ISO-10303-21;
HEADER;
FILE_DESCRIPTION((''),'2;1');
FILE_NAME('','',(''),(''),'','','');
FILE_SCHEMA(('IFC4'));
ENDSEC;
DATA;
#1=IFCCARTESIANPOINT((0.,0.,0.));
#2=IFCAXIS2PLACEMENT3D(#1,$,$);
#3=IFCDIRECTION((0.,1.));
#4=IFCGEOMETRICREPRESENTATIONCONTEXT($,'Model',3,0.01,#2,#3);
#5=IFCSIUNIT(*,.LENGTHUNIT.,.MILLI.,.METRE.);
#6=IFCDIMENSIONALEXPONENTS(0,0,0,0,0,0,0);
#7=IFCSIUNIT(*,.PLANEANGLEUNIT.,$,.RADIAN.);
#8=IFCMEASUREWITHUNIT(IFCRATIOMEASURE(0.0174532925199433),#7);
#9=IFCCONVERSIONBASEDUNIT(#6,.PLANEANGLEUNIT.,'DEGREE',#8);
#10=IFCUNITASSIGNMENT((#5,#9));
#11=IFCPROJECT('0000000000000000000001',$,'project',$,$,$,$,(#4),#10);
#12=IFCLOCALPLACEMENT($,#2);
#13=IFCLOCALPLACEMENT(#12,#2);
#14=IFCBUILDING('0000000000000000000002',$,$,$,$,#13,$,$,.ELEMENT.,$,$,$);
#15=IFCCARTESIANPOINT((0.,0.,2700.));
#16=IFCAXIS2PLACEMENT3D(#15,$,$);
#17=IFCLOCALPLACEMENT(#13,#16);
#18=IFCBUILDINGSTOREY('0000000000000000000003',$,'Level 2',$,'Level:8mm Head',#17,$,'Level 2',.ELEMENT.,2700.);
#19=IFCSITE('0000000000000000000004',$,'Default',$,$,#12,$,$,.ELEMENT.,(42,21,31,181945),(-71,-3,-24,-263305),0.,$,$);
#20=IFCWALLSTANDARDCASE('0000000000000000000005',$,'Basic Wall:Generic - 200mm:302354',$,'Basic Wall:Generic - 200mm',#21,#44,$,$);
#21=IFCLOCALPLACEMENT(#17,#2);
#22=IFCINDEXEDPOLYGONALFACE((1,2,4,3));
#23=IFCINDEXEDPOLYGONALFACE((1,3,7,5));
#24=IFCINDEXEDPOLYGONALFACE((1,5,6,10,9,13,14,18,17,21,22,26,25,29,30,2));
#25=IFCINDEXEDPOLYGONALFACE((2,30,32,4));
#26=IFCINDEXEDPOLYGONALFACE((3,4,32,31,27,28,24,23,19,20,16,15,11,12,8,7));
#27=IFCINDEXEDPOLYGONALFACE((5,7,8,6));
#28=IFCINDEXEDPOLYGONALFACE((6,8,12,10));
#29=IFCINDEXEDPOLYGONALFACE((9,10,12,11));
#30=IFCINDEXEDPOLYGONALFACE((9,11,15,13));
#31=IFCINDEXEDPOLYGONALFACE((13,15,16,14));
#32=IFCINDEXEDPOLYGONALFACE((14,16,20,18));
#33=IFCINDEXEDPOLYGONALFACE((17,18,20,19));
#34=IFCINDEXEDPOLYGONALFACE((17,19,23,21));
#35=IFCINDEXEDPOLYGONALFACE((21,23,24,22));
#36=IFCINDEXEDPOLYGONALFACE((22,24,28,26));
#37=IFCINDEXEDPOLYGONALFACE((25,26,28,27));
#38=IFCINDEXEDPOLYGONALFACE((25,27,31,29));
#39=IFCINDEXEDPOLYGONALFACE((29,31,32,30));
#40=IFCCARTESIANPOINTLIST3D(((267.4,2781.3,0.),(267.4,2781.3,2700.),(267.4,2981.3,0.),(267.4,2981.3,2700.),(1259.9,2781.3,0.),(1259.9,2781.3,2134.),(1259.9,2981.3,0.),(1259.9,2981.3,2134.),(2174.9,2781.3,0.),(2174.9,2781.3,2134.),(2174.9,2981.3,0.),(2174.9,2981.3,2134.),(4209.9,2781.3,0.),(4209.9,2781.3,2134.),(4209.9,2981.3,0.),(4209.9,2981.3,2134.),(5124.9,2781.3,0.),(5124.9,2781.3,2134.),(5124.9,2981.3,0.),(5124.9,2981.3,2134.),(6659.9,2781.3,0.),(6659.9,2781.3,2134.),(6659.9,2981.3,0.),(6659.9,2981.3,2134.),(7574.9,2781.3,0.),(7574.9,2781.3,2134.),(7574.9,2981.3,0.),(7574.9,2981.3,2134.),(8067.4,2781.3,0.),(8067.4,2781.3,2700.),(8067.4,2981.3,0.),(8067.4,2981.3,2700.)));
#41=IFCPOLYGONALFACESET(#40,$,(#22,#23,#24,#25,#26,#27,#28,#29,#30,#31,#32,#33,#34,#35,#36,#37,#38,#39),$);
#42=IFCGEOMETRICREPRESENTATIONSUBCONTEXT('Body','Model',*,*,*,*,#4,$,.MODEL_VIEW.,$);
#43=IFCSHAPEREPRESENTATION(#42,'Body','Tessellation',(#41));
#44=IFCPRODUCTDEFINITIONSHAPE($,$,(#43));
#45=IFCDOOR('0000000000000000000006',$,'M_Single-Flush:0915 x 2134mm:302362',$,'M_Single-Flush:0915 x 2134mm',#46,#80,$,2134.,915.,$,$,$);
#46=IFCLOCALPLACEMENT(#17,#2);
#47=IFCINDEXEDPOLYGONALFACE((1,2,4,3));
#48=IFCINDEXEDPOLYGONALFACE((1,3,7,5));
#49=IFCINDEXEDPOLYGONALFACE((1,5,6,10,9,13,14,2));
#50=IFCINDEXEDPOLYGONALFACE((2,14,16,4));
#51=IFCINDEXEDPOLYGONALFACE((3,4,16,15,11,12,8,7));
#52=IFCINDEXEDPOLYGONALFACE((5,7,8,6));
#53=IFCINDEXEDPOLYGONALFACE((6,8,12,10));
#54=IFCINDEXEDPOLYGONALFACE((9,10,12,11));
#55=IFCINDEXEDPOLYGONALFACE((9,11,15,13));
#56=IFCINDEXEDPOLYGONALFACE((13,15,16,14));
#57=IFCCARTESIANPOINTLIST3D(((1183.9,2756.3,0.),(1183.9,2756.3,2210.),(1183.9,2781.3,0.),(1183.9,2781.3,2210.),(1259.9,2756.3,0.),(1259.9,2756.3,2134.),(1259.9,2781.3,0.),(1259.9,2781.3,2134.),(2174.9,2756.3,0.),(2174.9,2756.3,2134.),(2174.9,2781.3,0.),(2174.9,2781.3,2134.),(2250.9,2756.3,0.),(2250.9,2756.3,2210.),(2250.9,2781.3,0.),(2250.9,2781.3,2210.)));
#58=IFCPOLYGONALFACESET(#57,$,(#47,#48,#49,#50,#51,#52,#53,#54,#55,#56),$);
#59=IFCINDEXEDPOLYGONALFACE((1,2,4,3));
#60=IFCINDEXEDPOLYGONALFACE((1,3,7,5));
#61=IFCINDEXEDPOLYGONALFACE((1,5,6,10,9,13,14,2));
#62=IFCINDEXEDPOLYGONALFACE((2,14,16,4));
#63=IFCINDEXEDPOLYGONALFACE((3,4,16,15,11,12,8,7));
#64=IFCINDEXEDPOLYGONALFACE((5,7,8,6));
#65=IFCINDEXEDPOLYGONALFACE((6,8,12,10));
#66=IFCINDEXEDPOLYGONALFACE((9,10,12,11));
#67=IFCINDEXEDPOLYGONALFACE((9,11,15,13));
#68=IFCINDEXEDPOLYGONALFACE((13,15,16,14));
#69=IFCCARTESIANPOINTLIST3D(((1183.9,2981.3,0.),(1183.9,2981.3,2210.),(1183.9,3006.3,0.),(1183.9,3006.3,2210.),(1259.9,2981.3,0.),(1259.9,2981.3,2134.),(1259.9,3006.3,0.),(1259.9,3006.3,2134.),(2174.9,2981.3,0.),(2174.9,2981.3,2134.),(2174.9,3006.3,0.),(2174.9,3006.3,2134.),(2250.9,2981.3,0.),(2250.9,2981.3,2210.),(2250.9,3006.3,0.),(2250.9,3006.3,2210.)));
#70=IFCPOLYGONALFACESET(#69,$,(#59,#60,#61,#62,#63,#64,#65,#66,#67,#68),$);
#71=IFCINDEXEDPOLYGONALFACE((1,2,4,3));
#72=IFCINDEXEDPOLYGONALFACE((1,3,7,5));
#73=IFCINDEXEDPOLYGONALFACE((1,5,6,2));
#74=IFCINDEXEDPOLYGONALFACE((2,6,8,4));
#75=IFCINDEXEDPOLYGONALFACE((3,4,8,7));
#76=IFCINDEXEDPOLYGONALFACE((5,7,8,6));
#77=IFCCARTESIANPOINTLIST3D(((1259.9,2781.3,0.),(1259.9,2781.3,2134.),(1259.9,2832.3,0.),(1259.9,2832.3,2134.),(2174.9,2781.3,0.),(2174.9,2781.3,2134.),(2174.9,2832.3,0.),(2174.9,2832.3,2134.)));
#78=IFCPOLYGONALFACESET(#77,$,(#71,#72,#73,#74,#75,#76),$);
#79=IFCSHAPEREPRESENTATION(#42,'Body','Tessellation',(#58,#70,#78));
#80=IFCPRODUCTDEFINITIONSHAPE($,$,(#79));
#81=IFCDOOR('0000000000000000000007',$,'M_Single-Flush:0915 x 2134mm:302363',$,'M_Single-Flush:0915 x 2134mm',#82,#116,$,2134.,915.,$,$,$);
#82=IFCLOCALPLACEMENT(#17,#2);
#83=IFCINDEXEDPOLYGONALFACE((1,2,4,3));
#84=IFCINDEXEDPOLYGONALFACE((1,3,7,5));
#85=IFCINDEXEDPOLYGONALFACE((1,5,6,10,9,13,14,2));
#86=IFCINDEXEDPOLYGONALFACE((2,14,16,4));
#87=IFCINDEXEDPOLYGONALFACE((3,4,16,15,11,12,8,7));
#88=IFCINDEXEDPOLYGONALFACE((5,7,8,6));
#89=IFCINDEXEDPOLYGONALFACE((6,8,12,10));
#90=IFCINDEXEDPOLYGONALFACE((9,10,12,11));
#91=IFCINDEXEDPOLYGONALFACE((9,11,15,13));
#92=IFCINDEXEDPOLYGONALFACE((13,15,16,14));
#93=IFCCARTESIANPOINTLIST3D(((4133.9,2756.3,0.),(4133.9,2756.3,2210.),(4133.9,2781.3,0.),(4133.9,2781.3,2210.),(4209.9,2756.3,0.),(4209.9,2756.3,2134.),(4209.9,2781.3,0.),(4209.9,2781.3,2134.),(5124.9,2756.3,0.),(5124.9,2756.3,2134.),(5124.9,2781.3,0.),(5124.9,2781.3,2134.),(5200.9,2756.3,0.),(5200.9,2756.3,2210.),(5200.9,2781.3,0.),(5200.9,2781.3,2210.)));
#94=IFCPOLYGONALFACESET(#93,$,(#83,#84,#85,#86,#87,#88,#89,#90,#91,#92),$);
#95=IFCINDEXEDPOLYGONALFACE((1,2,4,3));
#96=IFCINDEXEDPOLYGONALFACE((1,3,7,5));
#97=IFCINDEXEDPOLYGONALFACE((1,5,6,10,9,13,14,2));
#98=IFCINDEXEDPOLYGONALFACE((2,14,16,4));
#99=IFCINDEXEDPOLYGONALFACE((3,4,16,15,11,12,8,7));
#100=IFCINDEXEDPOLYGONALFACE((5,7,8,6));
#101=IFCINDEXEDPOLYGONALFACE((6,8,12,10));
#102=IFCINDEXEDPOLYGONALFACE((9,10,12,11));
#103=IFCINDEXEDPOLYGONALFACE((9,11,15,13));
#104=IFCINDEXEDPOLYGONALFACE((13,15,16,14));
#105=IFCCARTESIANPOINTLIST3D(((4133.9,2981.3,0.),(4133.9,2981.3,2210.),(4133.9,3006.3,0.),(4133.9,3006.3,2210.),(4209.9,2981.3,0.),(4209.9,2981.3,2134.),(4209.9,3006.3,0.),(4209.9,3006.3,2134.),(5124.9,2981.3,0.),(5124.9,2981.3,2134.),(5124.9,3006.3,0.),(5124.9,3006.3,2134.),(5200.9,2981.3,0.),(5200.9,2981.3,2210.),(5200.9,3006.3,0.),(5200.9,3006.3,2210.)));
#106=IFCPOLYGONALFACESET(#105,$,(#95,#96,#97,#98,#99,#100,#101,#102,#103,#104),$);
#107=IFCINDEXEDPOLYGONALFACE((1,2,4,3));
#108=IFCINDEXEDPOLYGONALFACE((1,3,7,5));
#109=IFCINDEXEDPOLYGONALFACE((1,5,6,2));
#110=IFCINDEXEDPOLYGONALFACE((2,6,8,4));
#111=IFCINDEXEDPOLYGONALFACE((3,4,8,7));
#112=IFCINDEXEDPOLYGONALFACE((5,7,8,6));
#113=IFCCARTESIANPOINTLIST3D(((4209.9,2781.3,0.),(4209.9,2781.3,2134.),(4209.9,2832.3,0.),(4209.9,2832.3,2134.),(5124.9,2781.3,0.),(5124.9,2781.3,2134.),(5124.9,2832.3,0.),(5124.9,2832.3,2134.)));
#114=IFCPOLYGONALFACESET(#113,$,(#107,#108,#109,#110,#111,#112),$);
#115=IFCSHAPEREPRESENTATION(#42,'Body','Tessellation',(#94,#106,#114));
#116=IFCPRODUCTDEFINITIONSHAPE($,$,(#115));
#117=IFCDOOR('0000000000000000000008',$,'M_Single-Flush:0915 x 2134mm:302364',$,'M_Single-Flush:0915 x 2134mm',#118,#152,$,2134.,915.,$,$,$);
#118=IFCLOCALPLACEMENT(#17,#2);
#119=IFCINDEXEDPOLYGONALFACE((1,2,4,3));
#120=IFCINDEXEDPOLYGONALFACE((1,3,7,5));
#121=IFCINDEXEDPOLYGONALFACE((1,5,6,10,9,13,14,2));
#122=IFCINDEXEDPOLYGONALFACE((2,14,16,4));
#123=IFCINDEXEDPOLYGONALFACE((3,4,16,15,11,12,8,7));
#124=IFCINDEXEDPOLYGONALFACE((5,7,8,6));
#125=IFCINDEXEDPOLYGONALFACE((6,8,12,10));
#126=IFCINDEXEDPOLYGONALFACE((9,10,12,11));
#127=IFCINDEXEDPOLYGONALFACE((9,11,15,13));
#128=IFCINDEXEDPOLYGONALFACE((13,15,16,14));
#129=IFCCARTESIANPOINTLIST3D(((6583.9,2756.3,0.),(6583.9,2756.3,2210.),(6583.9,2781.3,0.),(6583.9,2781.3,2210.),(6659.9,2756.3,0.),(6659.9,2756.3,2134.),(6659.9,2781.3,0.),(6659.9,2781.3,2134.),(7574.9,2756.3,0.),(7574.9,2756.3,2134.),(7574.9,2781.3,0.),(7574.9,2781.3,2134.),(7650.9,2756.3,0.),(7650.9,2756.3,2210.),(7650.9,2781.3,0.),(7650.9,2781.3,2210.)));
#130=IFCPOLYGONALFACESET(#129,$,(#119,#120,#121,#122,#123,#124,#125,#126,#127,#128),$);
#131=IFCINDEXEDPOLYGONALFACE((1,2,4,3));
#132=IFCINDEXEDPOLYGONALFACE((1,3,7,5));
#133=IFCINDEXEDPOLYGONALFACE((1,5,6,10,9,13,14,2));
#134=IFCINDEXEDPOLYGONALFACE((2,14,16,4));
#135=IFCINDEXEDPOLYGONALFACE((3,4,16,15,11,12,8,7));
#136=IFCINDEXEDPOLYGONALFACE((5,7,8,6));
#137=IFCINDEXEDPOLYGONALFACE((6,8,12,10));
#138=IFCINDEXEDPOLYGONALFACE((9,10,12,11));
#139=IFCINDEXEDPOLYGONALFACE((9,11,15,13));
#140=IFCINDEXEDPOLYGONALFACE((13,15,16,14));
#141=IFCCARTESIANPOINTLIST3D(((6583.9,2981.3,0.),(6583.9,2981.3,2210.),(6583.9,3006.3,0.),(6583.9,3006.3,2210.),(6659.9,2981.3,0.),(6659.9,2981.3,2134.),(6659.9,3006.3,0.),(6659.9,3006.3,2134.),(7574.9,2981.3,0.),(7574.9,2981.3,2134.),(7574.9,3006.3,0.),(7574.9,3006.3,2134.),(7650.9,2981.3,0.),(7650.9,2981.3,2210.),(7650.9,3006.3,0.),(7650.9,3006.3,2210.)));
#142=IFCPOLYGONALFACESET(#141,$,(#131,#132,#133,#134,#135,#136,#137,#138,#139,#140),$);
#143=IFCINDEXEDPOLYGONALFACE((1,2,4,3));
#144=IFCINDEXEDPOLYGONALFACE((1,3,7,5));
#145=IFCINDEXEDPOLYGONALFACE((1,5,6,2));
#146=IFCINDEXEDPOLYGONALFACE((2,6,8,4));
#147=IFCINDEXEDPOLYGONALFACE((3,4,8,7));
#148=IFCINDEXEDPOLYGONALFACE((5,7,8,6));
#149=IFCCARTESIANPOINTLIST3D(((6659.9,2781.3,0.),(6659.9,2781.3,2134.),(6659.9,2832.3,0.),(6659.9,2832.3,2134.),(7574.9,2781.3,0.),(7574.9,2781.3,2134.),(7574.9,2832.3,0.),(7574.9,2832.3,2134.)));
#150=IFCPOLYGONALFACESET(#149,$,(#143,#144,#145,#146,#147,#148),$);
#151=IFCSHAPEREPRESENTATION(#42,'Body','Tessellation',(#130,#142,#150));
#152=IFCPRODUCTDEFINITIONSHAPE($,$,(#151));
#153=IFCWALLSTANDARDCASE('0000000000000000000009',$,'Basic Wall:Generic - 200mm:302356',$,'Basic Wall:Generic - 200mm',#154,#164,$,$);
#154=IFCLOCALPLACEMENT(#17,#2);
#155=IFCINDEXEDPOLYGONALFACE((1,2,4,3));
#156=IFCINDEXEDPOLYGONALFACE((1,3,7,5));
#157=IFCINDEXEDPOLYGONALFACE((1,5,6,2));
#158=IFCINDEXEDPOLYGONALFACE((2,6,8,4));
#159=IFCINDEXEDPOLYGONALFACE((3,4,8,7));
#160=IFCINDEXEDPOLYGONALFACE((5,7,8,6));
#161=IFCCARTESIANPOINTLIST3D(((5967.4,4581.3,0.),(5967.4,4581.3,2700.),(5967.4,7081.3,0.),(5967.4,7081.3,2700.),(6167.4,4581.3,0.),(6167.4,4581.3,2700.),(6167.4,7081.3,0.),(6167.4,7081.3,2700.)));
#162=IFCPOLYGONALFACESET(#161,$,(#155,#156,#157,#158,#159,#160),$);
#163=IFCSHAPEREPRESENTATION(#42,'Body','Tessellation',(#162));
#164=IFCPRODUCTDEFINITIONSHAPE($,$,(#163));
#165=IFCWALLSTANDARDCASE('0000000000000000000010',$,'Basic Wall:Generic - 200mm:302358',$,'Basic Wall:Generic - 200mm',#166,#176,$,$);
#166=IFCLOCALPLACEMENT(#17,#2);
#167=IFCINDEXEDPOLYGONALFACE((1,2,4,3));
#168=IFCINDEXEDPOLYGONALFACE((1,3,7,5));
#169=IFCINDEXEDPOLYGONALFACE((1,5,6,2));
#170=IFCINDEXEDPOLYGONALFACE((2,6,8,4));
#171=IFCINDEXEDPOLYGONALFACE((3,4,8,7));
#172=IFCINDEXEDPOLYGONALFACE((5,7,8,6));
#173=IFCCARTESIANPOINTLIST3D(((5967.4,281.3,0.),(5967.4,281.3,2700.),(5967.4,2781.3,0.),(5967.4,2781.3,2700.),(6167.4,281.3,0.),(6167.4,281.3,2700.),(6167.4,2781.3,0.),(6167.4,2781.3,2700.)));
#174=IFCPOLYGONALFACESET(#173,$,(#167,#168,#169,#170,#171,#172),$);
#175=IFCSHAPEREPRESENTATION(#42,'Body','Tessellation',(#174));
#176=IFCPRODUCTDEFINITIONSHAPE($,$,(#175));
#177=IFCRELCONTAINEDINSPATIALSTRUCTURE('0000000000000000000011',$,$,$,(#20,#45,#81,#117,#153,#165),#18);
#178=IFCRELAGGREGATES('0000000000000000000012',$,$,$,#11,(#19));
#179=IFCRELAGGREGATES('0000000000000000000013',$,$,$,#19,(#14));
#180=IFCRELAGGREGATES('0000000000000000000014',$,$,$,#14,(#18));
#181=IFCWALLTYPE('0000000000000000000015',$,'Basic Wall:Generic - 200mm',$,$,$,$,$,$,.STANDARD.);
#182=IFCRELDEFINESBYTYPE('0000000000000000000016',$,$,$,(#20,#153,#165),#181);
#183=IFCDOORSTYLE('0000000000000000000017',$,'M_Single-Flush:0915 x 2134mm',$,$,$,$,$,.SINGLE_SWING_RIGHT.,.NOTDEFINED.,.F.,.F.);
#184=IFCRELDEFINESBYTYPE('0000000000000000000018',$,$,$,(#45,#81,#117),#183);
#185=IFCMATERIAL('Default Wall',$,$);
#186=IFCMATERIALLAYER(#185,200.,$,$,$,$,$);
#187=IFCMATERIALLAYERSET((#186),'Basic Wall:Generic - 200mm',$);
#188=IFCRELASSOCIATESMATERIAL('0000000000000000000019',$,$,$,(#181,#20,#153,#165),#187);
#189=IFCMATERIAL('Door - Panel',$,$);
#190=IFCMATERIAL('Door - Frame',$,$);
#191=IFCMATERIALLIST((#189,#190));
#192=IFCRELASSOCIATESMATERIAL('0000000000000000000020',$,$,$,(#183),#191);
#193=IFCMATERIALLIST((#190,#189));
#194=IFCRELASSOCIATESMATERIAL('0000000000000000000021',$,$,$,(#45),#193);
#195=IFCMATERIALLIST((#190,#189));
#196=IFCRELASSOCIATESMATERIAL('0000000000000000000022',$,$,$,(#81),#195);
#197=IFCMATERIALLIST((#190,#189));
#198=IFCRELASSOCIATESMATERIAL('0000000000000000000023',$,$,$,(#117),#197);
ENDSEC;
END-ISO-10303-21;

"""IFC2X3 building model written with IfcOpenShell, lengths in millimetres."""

from ifc_helpers import new_model, entity, si_unit, converted_unit, direction, frame, frame_2d, origin, place, context, subcontext, project, spatial, polyline, rectangle, outline, extrude, source, transform, mapped, material, material_list, layer, layer_set, layer_usage, type_object, type_shapes, element, fill, save


model = new_model("IFC2X3")

# Units and contexts
model_context = context("Model", 3, precision=0.01, world=origin(), true_north=direction((0.0, 1.0)))
body_context = subcontext(model_context, "Body", "Model", "MODEL_VIEW")
ifc_project = project(units=[si_unit("LENGTHUNIT", "METRE", prefix="MILLI"), converted_unit("PLANEANGLEUNIT", "DEGREE", entity("IfcRatioMeasure", 0.0174532925199433), si_unit("PLANEANGLEUNIT", "RADIAN"), dimensions=[0, 0, 0, 0, 0, 0, 0])], contexts=[model_context])

# Site, building, storey
site_placement = place(None, origin())
site = spatial("IfcSite", under=ifc_project, at=site_placement, Name="Default", CompositionType="ELEMENT", RefLatitude=(42, 21, 31, 181945), RefLongitude=(-71, -3, -24, -263305), RefElevation=0.0)
building_placement = place(site_placement, origin())
building = spatial("IfcBuilding", under=site, at=building_placement, CompositionType="ELEMENT")
storey_placement = place(building_placement, frame((0.0, 0.0, 2700.0)))
storey = spatial("IfcBuildingStorey", under=building, at=storey_placement, Name="Level 2", ObjectType="Level:8mm Head", LongName="Level 2", CompositionType="ELEMENT", Elevation=2700.0)

# Shared definitions
ifc_material_1 = material(Name="Default Wall")
ifc_layer = layer(ifc_material_1, 200.0)
ifc_layer_set = layer_set([ifc_layer], Name="Basic Wall:Generic - 200mm")
wall_type = type_object("IfcWallType", Name="Basic Wall:Generic - 200mm", PredefinedType="STANDARD", material=ifc_layer_set)

# Wall, openings, doors
ifc_layer_usage_1 = layer_usage(ifc_layer_set, "AXIS2", "NEGATIVE", 100.0)
wall_1_placement = place(storey_placement, frame((8067.4, 2881.3, 0.0), z_axis=(0.0, 0.0, 1.0), x_axis=(-1.0, 0.0, 0.0)))
wall_1 = element("IfcWallStandardCase", 1, at=wall_1_placement, inside=storey, type_object=wall_type, material=ifc_layer_usage_1, Name="Basic Wall:Generic - 200mm:302354", ObjectType="Basic Wall:Generic - 200mm", context=body_context, shape_type="SweptSolid", body=[
    extrude(rectangle(XDim=7800.0, YDim=200.0, at=frame_2d((3900.0, 0.0), x_axis=(-1.0, 0.0))), origin(), (0.0, 0.0, 1.0), 2700.0),
])
opening_1_placement = place(wall_1_placement, frame((5892.5, -100.0, 0.0)))
opening_1 = element("IfcOpeningElement", 2, at=opening_1_placement, cuts=wall_1, ObjectType="Opening", context=body_context, shape_type="SweptSolid", body=[
    extrude(rectangle(XDim=915.0, YDim=2134.0, at=frame_2d((1067.0, 457.5), x_axis=(0.0, 1.0))), frame((0.0, 0.0, 0.0), z_axis=(0.0, 1.0, 0.0), x_axis=(0.0, 0.0, 1.0)), (0.0, 0.0, 1.0), 200.0),
])
opening_2_placement = place(wall_1_placement, frame((2942.5, -100.0, 0.0)))
opening_2 = element("IfcOpeningElement", 3, at=opening_2_placement, cuts=wall_1, ObjectType="Opening", context=body_context, shape_type="SweptSolid", body=[
    extrude(rectangle(XDim=915.0, YDim=2134.0, at=frame_2d((1067.0, 457.5), x_axis=(0.0, 1.0))), frame((0.0, 0.0, 0.0), z_axis=(0.0, 1.0, 0.0), x_axis=(0.0, 0.0, 1.0)), (0.0, 0.0, 1.0), 200.0),
])
opening_3_placement = place(wall_1_placement, frame((492.5, -100.0, 0.0)))
opening_3 = element("IfcOpeningElement", 4, at=opening_3_placement, cuts=wall_1, ObjectType="Opening", context=body_context, shape_type="SweptSolid", body=[
    extrude(rectangle(XDim=915.0, YDim=2134.0, at=frame_2d((1067.0, 457.5), x_axis=(0.0, 1.0))), frame((0.0, 0.0, 0.0), z_axis=(0.0, 1.0, 0.0), x_axis=(0.0, 0.0, 1.0)), (0.0, 0.0, 1.0), 200.0),
])
ifc_material_2 = material(Name="Door - Frame")
ifc_material_3 = material(Name="Door - Panel")
ifc_material_list_1 = material_list([ifc_material_2, ifc_material_3])
ifc_material_list_2 = material_list([ifc_material_3, ifc_material_2])
door_style = type_object("IfcDoorStyle", Name="M_Single-Flush:0915 x 2134mm", ConstructionType="NOTDEFINED", OperationType="SINGLE_SWING_RIGHT", ParameterTakesPrecedence=False, Sizeable=False, material=ifc_material_list_2)
shared_shape_1 = source(origin(), body_context, "Body", "SweptSolid", [
    extrude(outline(polyline([(-533.5, -1124.0), (533.5, -1124.0), (533.5, 1086.0), (457.5, 1086.0), (457.5, -1048.0), (-457.5, -1048.0), (-457.5, 1086.0), (-533.5, 1086.0), (-533.5, -1124.0)])), frame((457.5, 200.0, 1086.0), z_axis=(0.0, 1.0, 0.0), x_axis=(1.0, 0.0, 0.0)), (0.0, 0.0, 1.0), 25.0),
    extrude(outline(polyline([(-1124.0, -533.5), (1086.0, -533.5), (1086.0, -457.5), (-1048.0, -457.5), (-1048.0, 457.5), (1086.0, 457.5), (1086.0, 533.5), (-1124.0, 533.5), (-1124.0, -533.5)])), frame((457.5, -25.0, 1086.0), z_axis=(0.0, 1.0, 0.0), x_axis=(0.0, 0.0, -1.0)), (0.0, 0.0, 1.0), 25.0),
    extrude(rectangle(XDim=51.0, YDim=915.0, at=frame_2d((0.0, 0.0), x_axis=(1.0, 0.0))), frame((457.5, 174.5, 0.0), z_axis=(0.0, 0.0, 1.0), x_axis=(0.0, 1.0, 0.0)), (0.0, 0.0, 1.0), 2134.0),
])
type_shapes(door_style, [shared_shape_1])
door_1_placement = place(opening_1_placement, origin())
door_1 = element("IfcDoor", 5, at=door_1_placement, inside=storey, type_object=door_style, material=ifc_material_list_1, Name="M_Single-Flush:0915 x 2134mm:302362", ObjectType="M_Single-Flush:0915 x 2134mm", OverallHeight=2134.0, OverallWidth=915.0, context=body_context, shape_type="MappedRepresentation", body=[
    mapped(shared_shape_1, transform((0.0, 0.0, 0.0), scale=1.0)),
])
fill(opening_1, door_1)
ifc_material_list_3 = material_list([ifc_material_2, ifc_material_3])
door_2_placement = place(opening_2_placement, origin())
door_2 = element("IfcDoor", 6, at=door_2_placement, inside=storey, type_object=door_style, material=ifc_material_list_3, Name="M_Single-Flush:0915 x 2134mm:302363", ObjectType="M_Single-Flush:0915 x 2134mm", OverallHeight=2134.0, OverallWidth=915.0, context=body_context, shape_type="MappedRepresentation", body=[
    mapped(shared_shape_1, transform((0.0, 0.0, 0.0), scale=1.0)),
])
fill(opening_2, door_2)
ifc_material_list_4 = material_list([ifc_material_2, ifc_material_3])
door_3_placement = place(opening_3_placement, origin())
door_3 = element("IfcDoor", 7, at=door_3_placement, inside=storey, type_object=door_style, material=ifc_material_list_4, Name="M_Single-Flush:0915 x 2134mm:302364", ObjectType="M_Single-Flush:0915 x 2134mm", OverallHeight=2134.0, OverallWidth=915.0, context=body_context, shape_type="MappedRepresentation", body=[
    mapped(shared_shape_1, transform((0.0, 0.0, 0.0), scale=1.0)),
])
fill(opening_3, door_3)

# Walls
ifc_layer_usage_2 = layer_usage(ifc_layer_set, "AXIS2", "NEGATIVE", 100.0)
wall_2_placement = place(storey_placement, frame((6067.4, 7081.3, 0.0), z_axis=(0.0, 0.0, 1.0), x_axis=(0.0, -1.0, 0.0)))
element("IfcWallStandardCase", 8, at=wall_2_placement, inside=storey, type_object=wall_type, material=ifc_layer_usage_2, Name="Basic Wall:Generic - 200mm:302356", ObjectType="Basic Wall:Generic - 200mm", context=body_context, shape_type="SweptSolid", body=[
    extrude(rectangle(XDim=2500.0, YDim=200.0, at=frame_2d((1250.0, 0.0), x_axis=(-1.0, 0.0))), origin(), (0.0, 0.0, 1.0), 2700.0),
])
ifc_layer_usage_3 = layer_usage(ifc_layer_set, "AXIS2", "NEGATIVE", 100.0)
wall_3_placement = place(storey_placement, frame((6067.4, 2781.3, 0.0), z_axis=(0.0, 0.0, 1.0), x_axis=(0.0, -1.0, 0.0)))
element("IfcWallStandardCase", 9, at=wall_3_placement, inside=storey, type_object=wall_type, material=ifc_layer_usage_3, Name="Basic Wall:Generic - 200mm:302358", ObjectType="Basic Wall:Generic - 200mm", context=body_context, shape_type="SweptSolid", body=[
    extrude(rectangle(XDim=2500.0, YDim=200.0, at=frame_2d((1250.0, 0.0), x_axis=(-1.0, 0.0))), origin(), (0.0, 0.0, 1.0), 2700.0),
])

save(model, "model.ifc")
